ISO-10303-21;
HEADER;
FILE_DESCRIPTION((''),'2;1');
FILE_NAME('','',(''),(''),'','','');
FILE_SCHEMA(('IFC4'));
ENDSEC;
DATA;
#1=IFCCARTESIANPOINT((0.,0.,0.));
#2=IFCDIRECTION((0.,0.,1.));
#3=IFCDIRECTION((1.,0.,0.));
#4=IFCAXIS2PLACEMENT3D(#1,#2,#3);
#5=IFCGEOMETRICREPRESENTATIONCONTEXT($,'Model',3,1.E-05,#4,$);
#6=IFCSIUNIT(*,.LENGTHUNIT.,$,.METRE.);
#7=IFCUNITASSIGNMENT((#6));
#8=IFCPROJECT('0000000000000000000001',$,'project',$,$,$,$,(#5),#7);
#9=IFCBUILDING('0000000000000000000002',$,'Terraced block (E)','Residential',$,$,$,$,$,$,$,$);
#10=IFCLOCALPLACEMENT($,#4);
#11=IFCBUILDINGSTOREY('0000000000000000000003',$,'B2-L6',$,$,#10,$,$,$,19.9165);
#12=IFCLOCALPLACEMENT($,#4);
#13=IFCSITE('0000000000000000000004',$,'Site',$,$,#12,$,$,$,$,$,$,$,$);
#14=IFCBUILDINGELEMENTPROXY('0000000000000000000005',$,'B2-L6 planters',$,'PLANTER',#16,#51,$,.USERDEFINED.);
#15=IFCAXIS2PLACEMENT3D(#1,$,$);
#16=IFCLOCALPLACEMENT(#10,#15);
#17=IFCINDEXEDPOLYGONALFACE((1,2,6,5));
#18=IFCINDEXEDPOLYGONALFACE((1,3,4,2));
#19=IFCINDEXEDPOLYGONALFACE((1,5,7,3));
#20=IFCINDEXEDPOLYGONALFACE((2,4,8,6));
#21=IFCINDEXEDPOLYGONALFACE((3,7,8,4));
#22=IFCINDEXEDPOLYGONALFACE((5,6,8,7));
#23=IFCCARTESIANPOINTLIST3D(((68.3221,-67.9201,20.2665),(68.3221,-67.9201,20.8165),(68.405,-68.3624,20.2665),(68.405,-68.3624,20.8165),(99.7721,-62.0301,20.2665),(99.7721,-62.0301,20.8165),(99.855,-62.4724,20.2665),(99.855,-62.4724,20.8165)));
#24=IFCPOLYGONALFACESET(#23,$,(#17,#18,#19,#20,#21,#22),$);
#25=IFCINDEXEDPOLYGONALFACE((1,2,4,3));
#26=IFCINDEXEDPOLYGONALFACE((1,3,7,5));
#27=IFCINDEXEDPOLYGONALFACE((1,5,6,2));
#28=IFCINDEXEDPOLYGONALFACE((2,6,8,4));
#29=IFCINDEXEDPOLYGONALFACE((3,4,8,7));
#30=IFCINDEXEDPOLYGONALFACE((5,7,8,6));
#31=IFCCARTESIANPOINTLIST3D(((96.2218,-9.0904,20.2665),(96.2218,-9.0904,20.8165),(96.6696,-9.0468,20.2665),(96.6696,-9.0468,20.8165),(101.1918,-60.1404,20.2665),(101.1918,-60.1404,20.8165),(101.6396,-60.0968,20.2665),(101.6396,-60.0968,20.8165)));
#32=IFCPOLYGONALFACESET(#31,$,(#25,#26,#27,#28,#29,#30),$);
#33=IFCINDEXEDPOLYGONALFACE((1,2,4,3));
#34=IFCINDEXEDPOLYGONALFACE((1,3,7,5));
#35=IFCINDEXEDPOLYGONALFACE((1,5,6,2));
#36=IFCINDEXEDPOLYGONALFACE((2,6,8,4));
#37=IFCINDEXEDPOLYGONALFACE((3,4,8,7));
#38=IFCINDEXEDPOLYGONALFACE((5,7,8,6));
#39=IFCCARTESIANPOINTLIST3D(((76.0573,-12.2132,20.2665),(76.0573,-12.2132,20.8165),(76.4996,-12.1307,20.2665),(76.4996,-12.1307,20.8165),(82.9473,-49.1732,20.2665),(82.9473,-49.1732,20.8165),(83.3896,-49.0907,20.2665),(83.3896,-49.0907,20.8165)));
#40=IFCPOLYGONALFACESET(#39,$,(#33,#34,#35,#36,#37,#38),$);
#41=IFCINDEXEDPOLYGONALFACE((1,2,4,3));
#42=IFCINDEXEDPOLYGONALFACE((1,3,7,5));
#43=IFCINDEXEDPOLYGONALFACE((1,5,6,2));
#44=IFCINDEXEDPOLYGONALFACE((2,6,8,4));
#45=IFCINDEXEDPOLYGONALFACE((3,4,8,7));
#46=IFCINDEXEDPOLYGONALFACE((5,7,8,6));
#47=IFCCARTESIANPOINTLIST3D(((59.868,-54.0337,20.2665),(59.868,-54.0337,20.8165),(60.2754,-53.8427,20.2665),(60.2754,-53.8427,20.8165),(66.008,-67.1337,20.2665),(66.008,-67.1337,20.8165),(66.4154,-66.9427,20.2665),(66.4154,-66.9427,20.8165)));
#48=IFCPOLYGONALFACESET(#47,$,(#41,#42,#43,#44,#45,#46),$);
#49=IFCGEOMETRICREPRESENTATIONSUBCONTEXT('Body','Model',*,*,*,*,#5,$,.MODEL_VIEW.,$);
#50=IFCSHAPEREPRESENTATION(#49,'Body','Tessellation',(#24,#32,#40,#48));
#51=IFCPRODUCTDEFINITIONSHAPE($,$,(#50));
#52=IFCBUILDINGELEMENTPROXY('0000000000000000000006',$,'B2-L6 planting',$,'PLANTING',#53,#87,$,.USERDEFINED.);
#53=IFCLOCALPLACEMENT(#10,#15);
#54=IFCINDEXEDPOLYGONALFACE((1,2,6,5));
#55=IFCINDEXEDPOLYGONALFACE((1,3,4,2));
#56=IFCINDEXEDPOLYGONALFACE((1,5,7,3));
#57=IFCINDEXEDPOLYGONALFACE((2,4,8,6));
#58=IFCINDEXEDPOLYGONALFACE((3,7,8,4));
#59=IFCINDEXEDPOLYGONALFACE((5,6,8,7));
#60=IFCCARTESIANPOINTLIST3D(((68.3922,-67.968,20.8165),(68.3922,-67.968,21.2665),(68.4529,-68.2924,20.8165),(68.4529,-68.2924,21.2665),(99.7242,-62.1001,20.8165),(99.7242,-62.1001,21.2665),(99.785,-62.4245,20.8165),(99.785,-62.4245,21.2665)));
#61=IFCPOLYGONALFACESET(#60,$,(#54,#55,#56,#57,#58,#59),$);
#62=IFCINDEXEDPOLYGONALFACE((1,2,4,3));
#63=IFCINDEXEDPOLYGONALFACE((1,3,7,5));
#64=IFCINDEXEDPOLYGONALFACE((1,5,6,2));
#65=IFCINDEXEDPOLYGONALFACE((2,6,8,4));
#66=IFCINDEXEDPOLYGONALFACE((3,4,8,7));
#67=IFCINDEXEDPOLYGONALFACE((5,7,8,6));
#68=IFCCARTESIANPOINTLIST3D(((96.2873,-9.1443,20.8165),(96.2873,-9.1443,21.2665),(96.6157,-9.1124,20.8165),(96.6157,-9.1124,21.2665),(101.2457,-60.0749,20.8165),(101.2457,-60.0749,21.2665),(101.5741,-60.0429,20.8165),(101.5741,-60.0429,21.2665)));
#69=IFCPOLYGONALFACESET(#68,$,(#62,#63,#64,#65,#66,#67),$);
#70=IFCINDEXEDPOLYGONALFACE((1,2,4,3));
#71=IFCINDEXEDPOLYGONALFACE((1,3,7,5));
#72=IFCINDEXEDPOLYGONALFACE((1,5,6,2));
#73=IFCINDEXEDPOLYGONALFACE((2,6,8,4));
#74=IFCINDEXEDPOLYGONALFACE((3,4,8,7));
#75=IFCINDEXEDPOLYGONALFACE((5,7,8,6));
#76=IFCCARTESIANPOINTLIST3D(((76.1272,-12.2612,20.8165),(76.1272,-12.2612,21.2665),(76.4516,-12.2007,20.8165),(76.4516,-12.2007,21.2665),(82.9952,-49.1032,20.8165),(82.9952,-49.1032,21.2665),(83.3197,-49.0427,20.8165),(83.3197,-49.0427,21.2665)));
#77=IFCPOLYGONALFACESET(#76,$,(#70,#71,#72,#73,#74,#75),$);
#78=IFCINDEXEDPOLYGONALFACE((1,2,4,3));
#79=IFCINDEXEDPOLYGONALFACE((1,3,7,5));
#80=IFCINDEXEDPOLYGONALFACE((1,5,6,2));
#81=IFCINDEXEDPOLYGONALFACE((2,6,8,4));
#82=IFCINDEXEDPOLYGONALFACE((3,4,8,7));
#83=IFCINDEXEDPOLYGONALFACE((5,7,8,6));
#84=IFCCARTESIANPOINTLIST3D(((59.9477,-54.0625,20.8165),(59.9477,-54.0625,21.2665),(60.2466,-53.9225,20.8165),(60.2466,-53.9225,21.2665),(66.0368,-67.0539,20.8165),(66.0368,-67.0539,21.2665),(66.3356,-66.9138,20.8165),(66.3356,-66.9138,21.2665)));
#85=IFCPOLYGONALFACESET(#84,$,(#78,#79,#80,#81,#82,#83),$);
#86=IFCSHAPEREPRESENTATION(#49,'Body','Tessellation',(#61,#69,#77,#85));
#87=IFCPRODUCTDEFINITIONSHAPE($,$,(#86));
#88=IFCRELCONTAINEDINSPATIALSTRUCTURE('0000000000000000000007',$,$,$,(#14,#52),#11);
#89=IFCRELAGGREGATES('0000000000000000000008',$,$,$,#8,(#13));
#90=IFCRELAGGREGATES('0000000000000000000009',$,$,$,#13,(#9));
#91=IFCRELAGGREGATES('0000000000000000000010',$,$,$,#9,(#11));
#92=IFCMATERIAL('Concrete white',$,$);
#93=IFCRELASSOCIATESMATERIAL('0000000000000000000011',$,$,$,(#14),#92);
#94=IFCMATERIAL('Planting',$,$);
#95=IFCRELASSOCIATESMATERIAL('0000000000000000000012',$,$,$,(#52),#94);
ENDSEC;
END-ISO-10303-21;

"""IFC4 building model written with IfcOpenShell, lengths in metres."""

from ifc_helpers import new_model, si_unit, frame, origin_with_axes, place, context, subcontext, project, spatial, polyline, outline, extrude, material, element, save


model = new_model("IFC4")

# Units and contexts
model_context = context("Model", 3, precision=1e-05, world=origin_with_axes())
body_context = subcontext(model_context, "Body", "Model", "MODEL_VIEW")
ifc_project = project(units=[si_unit("LENGTHUNIT", "METRE")], contexts=[model_context])

# Site, building, storey
site_placement = place(None, origin_with_axes())
site = spatial("IfcSite", under=ifc_project, at=site_placement, Name="Site")
building = spatial("IfcBuilding", under=site, Name="Terraced block (E)", Description="Residential")
storey_placement = place(None, origin_with_axes())
storey = spatial("IfcBuildingStorey", under=building, at=storey_placement, Name="B2-L6", Elevation=19.9165)

# Shared definitions
ifc_material_1 = material(Name="Concrete white")

# Building element proxies
proxy_1_placement = place(storey_placement, origin_with_axes())
element("IfcBuildingElementProxy", 1, at=proxy_1_placement, inside=storey, material=ifc_material_1, Name="B2-L6 planters", ObjectType="PLANTER", PredefinedType="USERDEFINED", context=body_context, shape_type="SweptSolid", body=[
    extrude(outline(polyline([(68.405, -68.3624), (99.855, -62.4724), (99.7721, -62.0301), (68.3221, -67.9201), (68.405, -68.3624)])), frame((0.0, 0.0, 20.2665), z_axis=(0.0, 0.0, 1.0), x_axis=(1.0, 0.0, 0.0)), (0.0, 0.0, 1.0), 0.55),
    extrude(outline(polyline([(101.6396, -60.0968), (96.6696, -9.0468), (96.2218, -9.0904), (101.1918, -60.1404), (101.6396, -60.0968)])), frame((0.0, 0.0, 20.2665), z_axis=(0.0, 0.0, 1.0), x_axis=(1.0, 0.0, 0.0)), (0.0, 0.0, 1.0), 0.55),
    extrude(outline(polyline([(76.0573, -12.2132), (82.9473, -49.1732), (83.3896, -49.0907), (76.4996, -12.1307), (76.0573, -12.2132)])), frame((0.0, 0.0, 20.2665), z_axis=(0.0, 0.0, 1.0), x_axis=(1.0, 0.0, 0.0)), (0.0, 0.0, 1.0), 0.55),
    extrude(outline(polyline([(59.868, -54.0337), (66.008, -67.1337), (66.4154, -66.9427), (60.2754, -53.8427), (59.868, -54.0337)])), frame((0.0, 0.0, 20.2665), z_axis=(0.0, 0.0, 1.0), x_axis=(1.0, 0.0, 0.0)), (0.0, 0.0, 1.0), 0.55),
])
ifc_material_2 = material(Name="Planting")
proxy_2_placement = place(storey_placement, origin_with_axes())
element("IfcBuildingElementProxy", 2, at=proxy_2_placement, inside=storey, material=ifc_material_2, Name="B2-L6 planting", ObjectType="PLANTING", PredefinedType="USERDEFINED", context=body_context, shape_type="SweptSolid", body=[
    extrude(outline(polyline([(68.4529, -68.2924), (99.785, -62.4245), (99.7242, -62.1001), (68.3922, -67.968), (68.4529, -68.2924)])), frame((0.0, 0.0, 20.8165), z_axis=(0.0, 0.0, 1.0), x_axis=(1.0, 0.0, 0.0)), (0.0, 0.0, 1.0), 0.45),
    extrude(outline(polyline([(101.5741, -60.0429), (96.6157, -9.1124), (96.2873, -9.1443), (101.2457, -60.0749), (101.5741, -60.0429)])), frame((0.0, 0.0, 20.8165), z_axis=(0.0, 0.0, 1.0), x_axis=(1.0, 0.0, 0.0)), (0.0, 0.0, 1.0), 0.45),
    extrude(outline(polyline([(76.1272, -12.2612), (82.9952, -49.1032), (83.3197, -49.0427), (76.4516, -12.2007), (76.1272, -12.2612)])), frame((0.0, 0.0, 20.8165), z_axis=(0.0, 0.0, 1.0), x_axis=(1.0, 0.0, 0.0)), (0.0, 0.0, 1.0), 0.45),
    extrude(outline(polyline([(59.9477, -54.0625), (66.0368, -67.0539), (66.3356, -66.9138), (60.2466, -53.9225), (59.9477, -54.0625)])), frame((0.0, 0.0, 20.8165), z_axis=(0.0, 0.0, 1.0), x_axis=(1.0, 0.0, 0.0)), (0.0, 0.0, 1.0), 0.45),
])

save(model, "model.ifc")
